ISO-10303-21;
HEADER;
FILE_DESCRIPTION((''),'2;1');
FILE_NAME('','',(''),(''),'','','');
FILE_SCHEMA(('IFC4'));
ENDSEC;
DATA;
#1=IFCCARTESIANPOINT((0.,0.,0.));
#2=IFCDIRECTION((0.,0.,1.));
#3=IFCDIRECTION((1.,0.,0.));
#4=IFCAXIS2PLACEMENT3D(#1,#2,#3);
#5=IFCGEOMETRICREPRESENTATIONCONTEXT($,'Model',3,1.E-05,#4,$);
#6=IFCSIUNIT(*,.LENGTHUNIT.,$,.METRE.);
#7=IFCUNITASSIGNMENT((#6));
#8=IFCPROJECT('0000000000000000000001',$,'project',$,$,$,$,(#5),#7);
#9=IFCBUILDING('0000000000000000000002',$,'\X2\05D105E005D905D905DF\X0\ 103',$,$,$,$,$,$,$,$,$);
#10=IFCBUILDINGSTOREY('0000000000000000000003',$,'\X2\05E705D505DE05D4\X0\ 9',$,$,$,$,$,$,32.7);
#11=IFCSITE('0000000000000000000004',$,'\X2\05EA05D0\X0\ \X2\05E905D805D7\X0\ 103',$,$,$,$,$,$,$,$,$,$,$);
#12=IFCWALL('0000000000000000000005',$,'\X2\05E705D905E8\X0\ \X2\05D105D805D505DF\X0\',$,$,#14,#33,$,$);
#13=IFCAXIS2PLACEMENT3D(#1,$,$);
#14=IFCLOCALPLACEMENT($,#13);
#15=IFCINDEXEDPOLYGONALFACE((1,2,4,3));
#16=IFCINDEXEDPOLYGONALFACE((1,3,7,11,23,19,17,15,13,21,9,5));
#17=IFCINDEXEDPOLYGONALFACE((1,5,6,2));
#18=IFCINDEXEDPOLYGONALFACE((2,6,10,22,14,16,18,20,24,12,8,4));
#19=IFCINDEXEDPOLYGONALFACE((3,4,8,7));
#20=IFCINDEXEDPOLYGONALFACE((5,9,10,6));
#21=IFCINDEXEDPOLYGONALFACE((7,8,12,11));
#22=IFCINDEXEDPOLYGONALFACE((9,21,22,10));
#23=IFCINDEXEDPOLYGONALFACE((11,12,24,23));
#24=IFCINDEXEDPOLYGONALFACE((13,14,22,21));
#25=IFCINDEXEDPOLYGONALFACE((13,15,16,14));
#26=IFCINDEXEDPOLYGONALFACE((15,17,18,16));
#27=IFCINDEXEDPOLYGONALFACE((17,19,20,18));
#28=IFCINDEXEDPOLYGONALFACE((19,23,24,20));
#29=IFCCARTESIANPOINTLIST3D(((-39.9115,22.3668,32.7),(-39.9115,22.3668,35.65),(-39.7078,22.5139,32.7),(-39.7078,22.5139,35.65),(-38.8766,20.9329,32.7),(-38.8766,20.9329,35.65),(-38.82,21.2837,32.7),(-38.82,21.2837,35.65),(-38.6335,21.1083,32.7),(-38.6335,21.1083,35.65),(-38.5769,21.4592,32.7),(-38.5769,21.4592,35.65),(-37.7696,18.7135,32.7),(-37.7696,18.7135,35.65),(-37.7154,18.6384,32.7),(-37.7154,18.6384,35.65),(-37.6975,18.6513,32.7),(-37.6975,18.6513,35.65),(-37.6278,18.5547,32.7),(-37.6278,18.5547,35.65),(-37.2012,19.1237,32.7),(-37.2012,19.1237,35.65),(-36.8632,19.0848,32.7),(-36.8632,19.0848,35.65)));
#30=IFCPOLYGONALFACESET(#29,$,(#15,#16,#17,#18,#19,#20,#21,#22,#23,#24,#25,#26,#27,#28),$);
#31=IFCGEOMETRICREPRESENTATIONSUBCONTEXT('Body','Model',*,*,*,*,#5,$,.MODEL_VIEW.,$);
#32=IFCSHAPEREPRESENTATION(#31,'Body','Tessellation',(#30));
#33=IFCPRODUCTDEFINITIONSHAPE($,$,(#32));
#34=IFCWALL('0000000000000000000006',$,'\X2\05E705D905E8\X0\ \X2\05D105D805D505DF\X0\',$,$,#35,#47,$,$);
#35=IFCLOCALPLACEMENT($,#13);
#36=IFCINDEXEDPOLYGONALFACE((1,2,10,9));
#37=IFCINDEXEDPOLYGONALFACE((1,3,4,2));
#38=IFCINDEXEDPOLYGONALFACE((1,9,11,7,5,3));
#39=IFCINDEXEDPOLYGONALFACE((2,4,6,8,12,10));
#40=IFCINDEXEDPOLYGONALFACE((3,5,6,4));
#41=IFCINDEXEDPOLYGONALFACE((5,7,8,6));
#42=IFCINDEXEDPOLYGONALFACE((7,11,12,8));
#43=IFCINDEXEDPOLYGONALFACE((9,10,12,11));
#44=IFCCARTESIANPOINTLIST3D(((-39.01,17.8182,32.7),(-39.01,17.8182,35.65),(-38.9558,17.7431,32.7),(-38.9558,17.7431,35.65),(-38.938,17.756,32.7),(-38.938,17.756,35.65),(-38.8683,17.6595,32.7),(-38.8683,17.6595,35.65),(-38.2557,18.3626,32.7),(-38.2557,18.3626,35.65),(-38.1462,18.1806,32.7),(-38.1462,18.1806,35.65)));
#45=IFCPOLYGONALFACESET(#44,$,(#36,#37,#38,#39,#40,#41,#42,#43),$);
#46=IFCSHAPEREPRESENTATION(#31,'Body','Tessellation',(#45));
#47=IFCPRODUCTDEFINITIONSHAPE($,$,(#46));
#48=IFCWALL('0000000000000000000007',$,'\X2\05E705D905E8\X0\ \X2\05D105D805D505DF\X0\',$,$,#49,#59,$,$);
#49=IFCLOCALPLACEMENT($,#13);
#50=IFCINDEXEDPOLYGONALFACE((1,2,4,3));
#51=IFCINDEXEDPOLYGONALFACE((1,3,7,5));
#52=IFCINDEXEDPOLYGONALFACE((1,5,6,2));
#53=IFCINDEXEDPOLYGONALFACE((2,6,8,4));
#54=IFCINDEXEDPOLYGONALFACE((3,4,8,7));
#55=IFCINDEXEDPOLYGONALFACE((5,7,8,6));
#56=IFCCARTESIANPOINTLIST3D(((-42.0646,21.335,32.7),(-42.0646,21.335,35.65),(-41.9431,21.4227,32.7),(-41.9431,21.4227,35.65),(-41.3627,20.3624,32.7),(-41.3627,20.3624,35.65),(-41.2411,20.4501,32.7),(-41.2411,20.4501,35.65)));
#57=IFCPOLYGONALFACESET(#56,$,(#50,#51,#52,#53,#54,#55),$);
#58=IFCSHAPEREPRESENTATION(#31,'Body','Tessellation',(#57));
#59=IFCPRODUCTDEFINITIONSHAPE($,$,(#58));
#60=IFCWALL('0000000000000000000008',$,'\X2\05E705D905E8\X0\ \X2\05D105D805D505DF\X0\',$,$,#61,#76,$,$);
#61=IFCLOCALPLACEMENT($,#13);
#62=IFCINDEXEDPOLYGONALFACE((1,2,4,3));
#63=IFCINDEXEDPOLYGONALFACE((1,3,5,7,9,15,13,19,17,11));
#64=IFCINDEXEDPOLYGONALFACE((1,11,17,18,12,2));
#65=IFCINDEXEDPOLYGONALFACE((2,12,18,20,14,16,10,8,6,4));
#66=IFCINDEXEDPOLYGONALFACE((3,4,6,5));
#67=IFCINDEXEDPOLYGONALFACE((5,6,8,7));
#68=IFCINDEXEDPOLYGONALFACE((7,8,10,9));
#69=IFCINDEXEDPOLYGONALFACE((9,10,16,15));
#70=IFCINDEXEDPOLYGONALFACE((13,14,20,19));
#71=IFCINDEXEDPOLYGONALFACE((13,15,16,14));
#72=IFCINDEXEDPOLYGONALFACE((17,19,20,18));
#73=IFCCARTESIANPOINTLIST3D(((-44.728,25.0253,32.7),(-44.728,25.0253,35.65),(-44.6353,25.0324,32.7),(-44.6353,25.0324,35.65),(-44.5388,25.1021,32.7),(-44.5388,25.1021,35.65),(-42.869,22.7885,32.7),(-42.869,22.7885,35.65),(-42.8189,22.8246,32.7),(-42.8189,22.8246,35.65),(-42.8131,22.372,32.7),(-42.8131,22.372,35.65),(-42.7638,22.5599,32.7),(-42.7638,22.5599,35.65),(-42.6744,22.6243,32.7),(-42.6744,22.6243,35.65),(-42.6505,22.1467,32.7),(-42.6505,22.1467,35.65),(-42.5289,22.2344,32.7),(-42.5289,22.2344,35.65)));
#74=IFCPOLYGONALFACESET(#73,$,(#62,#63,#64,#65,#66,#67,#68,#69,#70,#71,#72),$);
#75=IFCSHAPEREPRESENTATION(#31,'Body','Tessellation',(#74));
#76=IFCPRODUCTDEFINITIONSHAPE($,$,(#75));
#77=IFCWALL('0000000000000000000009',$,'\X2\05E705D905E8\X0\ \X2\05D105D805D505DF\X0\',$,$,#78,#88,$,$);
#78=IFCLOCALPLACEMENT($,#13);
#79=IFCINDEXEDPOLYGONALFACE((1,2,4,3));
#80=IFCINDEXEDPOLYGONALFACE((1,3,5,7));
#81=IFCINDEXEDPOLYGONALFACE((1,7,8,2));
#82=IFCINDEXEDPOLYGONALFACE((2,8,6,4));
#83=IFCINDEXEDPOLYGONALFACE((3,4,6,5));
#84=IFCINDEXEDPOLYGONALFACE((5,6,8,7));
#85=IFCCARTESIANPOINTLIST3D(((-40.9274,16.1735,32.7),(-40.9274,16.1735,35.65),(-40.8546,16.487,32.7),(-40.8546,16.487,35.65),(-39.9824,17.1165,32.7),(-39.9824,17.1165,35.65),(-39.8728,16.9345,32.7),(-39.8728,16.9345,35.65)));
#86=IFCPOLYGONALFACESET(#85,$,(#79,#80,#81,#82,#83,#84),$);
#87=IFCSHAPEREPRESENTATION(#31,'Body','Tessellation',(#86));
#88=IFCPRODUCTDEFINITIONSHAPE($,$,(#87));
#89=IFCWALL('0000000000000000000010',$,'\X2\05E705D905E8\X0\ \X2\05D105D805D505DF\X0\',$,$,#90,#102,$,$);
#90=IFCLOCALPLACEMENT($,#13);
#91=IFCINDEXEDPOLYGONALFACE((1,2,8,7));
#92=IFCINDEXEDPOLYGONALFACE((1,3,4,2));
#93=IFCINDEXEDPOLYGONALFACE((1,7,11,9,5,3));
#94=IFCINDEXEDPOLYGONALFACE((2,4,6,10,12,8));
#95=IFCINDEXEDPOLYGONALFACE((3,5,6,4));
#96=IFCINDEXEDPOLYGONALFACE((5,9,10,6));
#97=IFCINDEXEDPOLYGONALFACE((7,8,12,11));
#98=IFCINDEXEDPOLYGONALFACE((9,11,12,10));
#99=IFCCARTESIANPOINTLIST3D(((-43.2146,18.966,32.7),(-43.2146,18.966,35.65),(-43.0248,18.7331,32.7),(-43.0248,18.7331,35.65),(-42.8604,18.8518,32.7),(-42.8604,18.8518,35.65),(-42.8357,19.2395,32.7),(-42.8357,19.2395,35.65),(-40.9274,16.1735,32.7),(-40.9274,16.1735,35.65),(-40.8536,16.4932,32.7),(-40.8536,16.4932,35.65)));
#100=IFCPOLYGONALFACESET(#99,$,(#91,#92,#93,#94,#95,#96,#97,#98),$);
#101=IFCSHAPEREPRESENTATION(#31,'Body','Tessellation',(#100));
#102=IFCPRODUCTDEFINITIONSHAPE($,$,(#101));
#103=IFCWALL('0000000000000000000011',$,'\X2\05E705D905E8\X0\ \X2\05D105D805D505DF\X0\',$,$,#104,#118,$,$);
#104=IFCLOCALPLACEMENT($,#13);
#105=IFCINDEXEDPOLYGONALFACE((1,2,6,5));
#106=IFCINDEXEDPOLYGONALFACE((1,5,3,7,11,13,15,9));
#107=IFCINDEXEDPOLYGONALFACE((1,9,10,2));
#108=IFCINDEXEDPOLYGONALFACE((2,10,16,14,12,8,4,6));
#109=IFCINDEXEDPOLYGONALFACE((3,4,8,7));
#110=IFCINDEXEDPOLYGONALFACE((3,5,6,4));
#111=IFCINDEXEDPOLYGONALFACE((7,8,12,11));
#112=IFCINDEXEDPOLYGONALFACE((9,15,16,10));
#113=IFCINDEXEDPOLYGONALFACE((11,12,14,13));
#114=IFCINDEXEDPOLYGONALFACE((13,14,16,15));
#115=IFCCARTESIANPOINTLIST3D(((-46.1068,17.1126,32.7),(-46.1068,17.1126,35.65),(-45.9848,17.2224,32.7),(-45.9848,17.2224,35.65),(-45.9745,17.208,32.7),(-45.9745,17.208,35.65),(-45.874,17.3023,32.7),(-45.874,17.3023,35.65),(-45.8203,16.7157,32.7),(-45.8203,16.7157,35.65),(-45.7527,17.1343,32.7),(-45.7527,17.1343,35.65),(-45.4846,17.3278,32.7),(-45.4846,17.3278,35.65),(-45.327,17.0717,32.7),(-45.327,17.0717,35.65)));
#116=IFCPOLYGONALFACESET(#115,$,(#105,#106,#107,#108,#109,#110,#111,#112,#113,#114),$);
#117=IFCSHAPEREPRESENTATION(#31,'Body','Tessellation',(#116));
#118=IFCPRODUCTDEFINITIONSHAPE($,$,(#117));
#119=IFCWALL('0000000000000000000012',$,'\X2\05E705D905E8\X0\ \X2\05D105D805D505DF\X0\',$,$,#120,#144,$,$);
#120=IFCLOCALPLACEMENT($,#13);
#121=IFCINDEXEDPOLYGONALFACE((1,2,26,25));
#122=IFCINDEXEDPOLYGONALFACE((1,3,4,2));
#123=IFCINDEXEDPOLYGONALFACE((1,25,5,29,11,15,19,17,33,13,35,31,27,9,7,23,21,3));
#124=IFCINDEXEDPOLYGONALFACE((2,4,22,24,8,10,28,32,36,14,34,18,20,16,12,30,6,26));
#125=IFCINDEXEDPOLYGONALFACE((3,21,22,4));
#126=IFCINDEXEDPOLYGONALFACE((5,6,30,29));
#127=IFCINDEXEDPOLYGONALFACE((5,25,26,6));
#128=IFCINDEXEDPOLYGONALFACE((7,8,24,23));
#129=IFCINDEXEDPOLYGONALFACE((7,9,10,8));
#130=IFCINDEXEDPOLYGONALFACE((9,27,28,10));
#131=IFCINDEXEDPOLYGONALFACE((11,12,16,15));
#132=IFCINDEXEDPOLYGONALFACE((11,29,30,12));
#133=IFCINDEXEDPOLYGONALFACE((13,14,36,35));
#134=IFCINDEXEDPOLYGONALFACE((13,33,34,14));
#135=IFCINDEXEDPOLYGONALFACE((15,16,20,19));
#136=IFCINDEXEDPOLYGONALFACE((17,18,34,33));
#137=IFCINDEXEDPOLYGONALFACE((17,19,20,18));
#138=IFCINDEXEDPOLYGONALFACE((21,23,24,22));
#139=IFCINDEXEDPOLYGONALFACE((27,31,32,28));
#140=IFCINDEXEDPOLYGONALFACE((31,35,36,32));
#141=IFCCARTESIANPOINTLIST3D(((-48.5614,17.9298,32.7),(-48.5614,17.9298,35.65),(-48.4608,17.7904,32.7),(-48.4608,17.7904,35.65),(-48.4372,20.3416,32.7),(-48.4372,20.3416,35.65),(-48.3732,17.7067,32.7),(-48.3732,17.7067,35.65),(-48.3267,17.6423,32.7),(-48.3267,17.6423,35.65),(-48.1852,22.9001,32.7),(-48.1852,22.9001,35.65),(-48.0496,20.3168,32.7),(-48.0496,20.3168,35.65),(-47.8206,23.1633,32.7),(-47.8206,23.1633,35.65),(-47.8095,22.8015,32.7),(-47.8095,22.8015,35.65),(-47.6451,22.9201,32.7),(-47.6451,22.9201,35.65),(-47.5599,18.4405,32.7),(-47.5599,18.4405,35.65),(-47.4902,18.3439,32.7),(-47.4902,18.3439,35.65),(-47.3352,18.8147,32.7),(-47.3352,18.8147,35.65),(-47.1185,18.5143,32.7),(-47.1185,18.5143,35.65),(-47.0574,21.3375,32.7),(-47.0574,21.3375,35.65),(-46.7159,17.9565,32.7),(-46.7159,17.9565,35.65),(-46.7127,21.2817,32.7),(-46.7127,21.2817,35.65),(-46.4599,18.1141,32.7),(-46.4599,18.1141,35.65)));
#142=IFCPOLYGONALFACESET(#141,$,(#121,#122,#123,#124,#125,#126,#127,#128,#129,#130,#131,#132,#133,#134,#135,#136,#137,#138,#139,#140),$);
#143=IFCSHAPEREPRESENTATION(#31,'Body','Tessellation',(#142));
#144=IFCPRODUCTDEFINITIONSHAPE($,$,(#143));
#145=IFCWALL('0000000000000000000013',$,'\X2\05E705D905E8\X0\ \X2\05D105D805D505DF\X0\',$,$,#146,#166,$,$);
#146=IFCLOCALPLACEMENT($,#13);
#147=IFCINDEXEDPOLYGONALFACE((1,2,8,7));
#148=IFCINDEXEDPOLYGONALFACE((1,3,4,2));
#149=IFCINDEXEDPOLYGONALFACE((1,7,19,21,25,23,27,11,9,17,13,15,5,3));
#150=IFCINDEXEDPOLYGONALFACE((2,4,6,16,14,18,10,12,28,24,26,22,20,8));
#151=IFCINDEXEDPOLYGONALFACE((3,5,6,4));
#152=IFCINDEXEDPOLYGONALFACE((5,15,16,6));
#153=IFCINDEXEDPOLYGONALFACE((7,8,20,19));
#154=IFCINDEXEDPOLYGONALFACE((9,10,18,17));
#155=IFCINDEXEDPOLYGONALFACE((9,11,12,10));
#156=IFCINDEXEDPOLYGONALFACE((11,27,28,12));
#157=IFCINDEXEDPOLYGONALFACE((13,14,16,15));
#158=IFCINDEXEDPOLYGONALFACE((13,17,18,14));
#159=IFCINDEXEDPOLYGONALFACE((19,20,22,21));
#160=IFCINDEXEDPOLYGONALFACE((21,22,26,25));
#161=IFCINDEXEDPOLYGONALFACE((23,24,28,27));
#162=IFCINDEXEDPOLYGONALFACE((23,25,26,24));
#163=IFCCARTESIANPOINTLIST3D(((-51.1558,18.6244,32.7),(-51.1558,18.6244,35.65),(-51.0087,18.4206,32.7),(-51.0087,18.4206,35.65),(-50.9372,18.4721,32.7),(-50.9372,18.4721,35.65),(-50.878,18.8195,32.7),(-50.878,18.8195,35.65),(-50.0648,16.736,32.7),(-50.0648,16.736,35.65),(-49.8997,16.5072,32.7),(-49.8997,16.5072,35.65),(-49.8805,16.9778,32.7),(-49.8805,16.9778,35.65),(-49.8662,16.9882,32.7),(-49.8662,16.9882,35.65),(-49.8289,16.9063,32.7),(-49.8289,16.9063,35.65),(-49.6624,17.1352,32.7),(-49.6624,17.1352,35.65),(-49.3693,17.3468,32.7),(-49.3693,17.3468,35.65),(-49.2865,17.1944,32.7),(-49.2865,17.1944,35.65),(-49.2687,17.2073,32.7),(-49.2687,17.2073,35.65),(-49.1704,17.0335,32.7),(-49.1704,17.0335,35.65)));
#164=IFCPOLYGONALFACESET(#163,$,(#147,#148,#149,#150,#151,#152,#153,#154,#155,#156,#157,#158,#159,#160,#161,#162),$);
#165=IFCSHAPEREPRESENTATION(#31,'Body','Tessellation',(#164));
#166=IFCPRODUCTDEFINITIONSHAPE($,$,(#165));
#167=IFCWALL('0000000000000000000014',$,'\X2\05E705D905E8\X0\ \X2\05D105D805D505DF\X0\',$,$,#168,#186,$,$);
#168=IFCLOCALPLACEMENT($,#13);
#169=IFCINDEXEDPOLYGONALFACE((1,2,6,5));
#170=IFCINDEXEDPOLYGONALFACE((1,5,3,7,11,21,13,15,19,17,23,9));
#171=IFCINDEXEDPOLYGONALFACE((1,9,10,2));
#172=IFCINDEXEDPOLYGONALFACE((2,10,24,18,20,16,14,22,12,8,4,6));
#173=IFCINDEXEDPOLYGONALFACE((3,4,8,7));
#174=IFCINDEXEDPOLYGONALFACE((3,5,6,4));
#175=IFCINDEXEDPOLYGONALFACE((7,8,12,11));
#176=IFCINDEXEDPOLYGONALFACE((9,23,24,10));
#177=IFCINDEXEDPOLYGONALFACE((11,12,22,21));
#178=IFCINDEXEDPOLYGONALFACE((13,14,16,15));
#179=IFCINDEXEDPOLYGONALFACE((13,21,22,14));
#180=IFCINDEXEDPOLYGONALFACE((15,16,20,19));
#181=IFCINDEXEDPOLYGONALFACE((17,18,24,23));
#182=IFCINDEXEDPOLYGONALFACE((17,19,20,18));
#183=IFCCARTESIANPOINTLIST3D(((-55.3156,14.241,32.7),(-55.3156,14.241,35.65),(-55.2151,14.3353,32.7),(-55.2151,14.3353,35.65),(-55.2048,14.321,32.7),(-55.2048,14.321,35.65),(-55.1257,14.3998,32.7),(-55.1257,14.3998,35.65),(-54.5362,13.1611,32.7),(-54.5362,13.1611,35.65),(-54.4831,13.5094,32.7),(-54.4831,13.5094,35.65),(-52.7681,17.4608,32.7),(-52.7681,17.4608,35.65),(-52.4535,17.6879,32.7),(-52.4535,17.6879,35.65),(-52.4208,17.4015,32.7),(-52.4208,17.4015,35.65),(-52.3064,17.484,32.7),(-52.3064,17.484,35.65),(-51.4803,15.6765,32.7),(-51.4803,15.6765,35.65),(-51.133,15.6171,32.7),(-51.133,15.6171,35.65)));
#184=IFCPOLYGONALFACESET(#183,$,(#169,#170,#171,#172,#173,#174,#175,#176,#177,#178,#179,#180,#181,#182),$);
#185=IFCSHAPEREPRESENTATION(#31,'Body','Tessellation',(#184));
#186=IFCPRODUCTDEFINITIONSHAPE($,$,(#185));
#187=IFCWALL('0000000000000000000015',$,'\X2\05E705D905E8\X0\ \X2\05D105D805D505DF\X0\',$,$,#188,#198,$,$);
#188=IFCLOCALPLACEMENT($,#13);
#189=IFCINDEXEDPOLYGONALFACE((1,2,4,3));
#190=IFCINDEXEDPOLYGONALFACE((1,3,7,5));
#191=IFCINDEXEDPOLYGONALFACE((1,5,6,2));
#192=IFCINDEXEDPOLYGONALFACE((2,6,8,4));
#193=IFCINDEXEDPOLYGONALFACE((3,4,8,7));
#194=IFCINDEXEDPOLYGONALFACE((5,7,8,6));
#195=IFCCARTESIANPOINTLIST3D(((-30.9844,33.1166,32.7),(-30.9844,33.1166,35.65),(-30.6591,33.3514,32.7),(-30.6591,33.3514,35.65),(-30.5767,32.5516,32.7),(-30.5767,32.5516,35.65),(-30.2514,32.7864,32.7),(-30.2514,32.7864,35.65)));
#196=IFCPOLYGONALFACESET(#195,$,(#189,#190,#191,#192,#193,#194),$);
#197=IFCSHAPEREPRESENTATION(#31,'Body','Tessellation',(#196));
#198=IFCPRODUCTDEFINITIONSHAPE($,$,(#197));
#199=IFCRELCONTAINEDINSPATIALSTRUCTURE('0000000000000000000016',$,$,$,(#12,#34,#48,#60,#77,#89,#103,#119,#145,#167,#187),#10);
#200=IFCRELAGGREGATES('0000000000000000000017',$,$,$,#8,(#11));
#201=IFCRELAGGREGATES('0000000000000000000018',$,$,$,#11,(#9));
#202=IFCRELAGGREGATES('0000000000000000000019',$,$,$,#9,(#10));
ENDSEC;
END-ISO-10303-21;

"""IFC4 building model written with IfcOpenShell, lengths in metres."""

from ifc_helpers import new_model, si_unit, frame, origin_with_axes, context, subcontext, project, spatial, polyline, outline, extrude, element, save


model = new_model("IFC4")

# Units and contexts
model_context = context("Model", 3, precision=1e-05, world=origin_with_axes())
body_context = subcontext(model_context, "Body", "Model", "MODEL_VIEW")
ifc_project = project(units=[si_unit("LENGTHUNIT", "METRE")], contexts=[model_context])

# Site, building, storey
site = spatial("IfcSite", under=ifc_project, Name="תא שטח 103")
building = spatial("IfcBuilding", under=site, Name="בניין 103")
storey = spatial("IfcBuildingStorey", under=building, Name="קומה 9", Elevation=32.7)

# Walls
element("IfcWall", 1, inside=storey, Name="קיר בטון", context=body_context, shape_type="SweptSolid", body=[
    extrude(outline(polyline([(-37.6975, 18.6513), (-37.7154, 18.6384), (-37.7696, 18.7135), (-37.2012, 19.1237), (-38.6335, 21.1083), (-38.8766, 20.9329), (-39.9115, 22.3668), (-39.7078, 22.5139), (-38.82, 21.2837), (-38.5769, 21.4592), (-36.8632, 19.0848), (-37.6278, 18.5547), (-37.6975, 18.6513)])), frame((0.0, 0.0, 32.7)), (0.0, 0.0, 1.0), 2.95),
])
element("IfcWall", 2, inside=storey, Name="קיר בטון", context=body_context, shape_type="SweptSolid", body=[
    extrude(outline(polyline([(-38.938, 17.756), (-38.9558, 17.7431), (-39.01, 17.8182), (-38.2557, 18.3626), (-38.1462, 18.1806), (-38.8683, 17.6595), (-38.938, 17.756)])), frame((0.0, 0.0, 32.7)), (0.0, 0.0, 1.0), 2.95),
])
element("IfcWall", 3, inside=storey, Name="קיר בטון", context=body_context, shape_type="SweptSolid", body=[
    extrude(outline(polyline([(-41.2411, 20.4501), (-41.3627, 20.3624), (-42.0646, 21.335), (-41.9431, 21.4227), (-41.2411, 20.4501)])), frame((0.0, 0.0, 32.7)), (0.0, 0.0, 1.0), 2.95),
])
element("IfcWall", 4, inside=storey, Name="קיר בטון", context=body_context, shape_type="SweptSolid", body=[
    extrude(outline(polyline([(-42.6505, 22.1467), (-42.8131, 22.372), (-44.728, 25.0253), (-44.6353, 25.0324), (-44.5388, 25.1021), (-42.869, 22.7885), (-42.8189, 22.8246), (-42.6744, 22.6243), (-42.7638, 22.5599), (-42.5289, 22.2344), (-42.6505, 22.1467)])), frame((0.0, 0.0, 32.7)), (0.0, 0.0, 1.0), 2.95),
])
element("IfcWall", 5, inside=storey, Name="קיר בטון", context=body_context, shape_type="SweptSolid", body=[
    extrude(outline(polyline([(-40.9274, 16.1735), (-40.8546, 16.487), (-39.9824, 17.1165), (-39.8728, 16.9345), (-40.9274, 16.1735)])), frame((0.0, 0.0, 32.7)), (0.0, 0.0, 1.0), 2.95),
])
element("IfcWall", 6, inside=storey, Name="קיר בטון", context=body_context, shape_type="SweptSolid", body=[
    extrude(outline(polyline([(-43.0248, 18.7331), (-43.2146, 18.966), (-42.8357, 19.2395), (-40.8536, 16.4932), (-40.9274, 16.1735), (-42.8604, 18.8518), (-43.0248, 18.7331)])), frame((0.0, 0.0, 32.7)), (0.0, 0.0, 1.0), 2.95),
])
element("IfcWall", 7, inside=storey, Name="קיר בטון", context=body_context, shape_type="SweptSolid", body=[
    extrude(outline(polyline([(-45.9745, 17.208), (-45.9848, 17.2224), (-45.874, 17.3023), (-45.7527, 17.1343), (-45.4846, 17.3278), (-45.327, 17.0717), (-45.8203, 16.7157), (-46.1068, 17.1126), (-45.9745, 17.208)])), frame((0.0, 0.0, 32.7)), (0.0, 0.0, 1.0), 2.95),
])
element("IfcWall", 8, inside=storey, Name="קיר בטון", context=body_context, shape_type="SweptSolid", body=[
    extrude(outline(polyline([(-48.4608, 17.7904), (-48.5614, 17.9298), (-47.3352, 18.8147), (-48.4372, 20.3416), (-47.0574, 21.3375), (-48.1852, 22.9001), (-47.8206, 23.1633), (-47.6451, 22.9201), (-47.8095, 22.8015), (-46.7127, 21.2817), (-48.0496, 20.3168), (-46.4599, 18.1141), (-46.7159, 17.9565), (-47.1185, 18.5143), (-48.3267, 17.6423), (-48.3732, 17.7067), (-47.4902, 18.3439), (-47.5599, 18.4405), (-48.4608, 17.7904)])), frame((0.0, 0.0, 32.7)), (0.0, 0.0, 1.0), 2.95),
])
element("IfcWall", 9, inside=storey, Name="קיר בטון", context=body_context, shape_type="SweptSolid", body=[
    extrude(outline(polyline([(-49.2865, 17.1944), (-49.1704, 17.0335), (-49.8997, 16.5072), (-50.0648, 16.736), (-49.8289, 16.9063), (-49.8805, 16.9778), (-49.8662, 16.9882), (-50.9372, 18.4721), (-51.0087, 18.4206), (-51.1558, 18.6244), (-50.878, 18.8195), (-49.6624, 17.1352), (-49.3693, 17.3468), (-49.2687, 17.2073), (-49.2865, 17.1944)])), frame((0.0, 0.0, 32.7)), (0.0, 0.0, 1.0), 2.95),
])
element("IfcWall", 10, inside=storey, Name="קיר בטון", context=body_context, shape_type="SweptSolid", body=[
    extrude(outline(polyline([(-54.5362, 13.1611), (-55.3156, 14.241), (-55.2048, 14.321), (-55.2151, 14.3353), (-55.1257, 14.3998), (-54.4831, 13.5094), (-51.4803, 15.6765), (-52.7681, 17.4608), (-52.4535, 17.6879), (-52.3064, 17.484), (-52.4208, 17.4015), (-51.133, 15.6171), (-54.5362, 13.1611)])), frame((0.0, 0.0, 32.7)), (0.0, 0.0, 1.0), 2.95),
])
element("IfcWall", 11, inside=storey, Name="קיר בטון", context=body_context, shape_type="SweptSolid", body=[
    extrude(outline(polyline([(-30.9844, 33.1166), (-30.6591, 33.3514), (-30.2514, 32.7864), (-30.5767, 32.5516), (-30.9844, 33.1166)])), frame((0.0, 0.0, 32.7)), (0.0, 0.0, 1.0), 2.95),
])

save(model, "model.ifc")
